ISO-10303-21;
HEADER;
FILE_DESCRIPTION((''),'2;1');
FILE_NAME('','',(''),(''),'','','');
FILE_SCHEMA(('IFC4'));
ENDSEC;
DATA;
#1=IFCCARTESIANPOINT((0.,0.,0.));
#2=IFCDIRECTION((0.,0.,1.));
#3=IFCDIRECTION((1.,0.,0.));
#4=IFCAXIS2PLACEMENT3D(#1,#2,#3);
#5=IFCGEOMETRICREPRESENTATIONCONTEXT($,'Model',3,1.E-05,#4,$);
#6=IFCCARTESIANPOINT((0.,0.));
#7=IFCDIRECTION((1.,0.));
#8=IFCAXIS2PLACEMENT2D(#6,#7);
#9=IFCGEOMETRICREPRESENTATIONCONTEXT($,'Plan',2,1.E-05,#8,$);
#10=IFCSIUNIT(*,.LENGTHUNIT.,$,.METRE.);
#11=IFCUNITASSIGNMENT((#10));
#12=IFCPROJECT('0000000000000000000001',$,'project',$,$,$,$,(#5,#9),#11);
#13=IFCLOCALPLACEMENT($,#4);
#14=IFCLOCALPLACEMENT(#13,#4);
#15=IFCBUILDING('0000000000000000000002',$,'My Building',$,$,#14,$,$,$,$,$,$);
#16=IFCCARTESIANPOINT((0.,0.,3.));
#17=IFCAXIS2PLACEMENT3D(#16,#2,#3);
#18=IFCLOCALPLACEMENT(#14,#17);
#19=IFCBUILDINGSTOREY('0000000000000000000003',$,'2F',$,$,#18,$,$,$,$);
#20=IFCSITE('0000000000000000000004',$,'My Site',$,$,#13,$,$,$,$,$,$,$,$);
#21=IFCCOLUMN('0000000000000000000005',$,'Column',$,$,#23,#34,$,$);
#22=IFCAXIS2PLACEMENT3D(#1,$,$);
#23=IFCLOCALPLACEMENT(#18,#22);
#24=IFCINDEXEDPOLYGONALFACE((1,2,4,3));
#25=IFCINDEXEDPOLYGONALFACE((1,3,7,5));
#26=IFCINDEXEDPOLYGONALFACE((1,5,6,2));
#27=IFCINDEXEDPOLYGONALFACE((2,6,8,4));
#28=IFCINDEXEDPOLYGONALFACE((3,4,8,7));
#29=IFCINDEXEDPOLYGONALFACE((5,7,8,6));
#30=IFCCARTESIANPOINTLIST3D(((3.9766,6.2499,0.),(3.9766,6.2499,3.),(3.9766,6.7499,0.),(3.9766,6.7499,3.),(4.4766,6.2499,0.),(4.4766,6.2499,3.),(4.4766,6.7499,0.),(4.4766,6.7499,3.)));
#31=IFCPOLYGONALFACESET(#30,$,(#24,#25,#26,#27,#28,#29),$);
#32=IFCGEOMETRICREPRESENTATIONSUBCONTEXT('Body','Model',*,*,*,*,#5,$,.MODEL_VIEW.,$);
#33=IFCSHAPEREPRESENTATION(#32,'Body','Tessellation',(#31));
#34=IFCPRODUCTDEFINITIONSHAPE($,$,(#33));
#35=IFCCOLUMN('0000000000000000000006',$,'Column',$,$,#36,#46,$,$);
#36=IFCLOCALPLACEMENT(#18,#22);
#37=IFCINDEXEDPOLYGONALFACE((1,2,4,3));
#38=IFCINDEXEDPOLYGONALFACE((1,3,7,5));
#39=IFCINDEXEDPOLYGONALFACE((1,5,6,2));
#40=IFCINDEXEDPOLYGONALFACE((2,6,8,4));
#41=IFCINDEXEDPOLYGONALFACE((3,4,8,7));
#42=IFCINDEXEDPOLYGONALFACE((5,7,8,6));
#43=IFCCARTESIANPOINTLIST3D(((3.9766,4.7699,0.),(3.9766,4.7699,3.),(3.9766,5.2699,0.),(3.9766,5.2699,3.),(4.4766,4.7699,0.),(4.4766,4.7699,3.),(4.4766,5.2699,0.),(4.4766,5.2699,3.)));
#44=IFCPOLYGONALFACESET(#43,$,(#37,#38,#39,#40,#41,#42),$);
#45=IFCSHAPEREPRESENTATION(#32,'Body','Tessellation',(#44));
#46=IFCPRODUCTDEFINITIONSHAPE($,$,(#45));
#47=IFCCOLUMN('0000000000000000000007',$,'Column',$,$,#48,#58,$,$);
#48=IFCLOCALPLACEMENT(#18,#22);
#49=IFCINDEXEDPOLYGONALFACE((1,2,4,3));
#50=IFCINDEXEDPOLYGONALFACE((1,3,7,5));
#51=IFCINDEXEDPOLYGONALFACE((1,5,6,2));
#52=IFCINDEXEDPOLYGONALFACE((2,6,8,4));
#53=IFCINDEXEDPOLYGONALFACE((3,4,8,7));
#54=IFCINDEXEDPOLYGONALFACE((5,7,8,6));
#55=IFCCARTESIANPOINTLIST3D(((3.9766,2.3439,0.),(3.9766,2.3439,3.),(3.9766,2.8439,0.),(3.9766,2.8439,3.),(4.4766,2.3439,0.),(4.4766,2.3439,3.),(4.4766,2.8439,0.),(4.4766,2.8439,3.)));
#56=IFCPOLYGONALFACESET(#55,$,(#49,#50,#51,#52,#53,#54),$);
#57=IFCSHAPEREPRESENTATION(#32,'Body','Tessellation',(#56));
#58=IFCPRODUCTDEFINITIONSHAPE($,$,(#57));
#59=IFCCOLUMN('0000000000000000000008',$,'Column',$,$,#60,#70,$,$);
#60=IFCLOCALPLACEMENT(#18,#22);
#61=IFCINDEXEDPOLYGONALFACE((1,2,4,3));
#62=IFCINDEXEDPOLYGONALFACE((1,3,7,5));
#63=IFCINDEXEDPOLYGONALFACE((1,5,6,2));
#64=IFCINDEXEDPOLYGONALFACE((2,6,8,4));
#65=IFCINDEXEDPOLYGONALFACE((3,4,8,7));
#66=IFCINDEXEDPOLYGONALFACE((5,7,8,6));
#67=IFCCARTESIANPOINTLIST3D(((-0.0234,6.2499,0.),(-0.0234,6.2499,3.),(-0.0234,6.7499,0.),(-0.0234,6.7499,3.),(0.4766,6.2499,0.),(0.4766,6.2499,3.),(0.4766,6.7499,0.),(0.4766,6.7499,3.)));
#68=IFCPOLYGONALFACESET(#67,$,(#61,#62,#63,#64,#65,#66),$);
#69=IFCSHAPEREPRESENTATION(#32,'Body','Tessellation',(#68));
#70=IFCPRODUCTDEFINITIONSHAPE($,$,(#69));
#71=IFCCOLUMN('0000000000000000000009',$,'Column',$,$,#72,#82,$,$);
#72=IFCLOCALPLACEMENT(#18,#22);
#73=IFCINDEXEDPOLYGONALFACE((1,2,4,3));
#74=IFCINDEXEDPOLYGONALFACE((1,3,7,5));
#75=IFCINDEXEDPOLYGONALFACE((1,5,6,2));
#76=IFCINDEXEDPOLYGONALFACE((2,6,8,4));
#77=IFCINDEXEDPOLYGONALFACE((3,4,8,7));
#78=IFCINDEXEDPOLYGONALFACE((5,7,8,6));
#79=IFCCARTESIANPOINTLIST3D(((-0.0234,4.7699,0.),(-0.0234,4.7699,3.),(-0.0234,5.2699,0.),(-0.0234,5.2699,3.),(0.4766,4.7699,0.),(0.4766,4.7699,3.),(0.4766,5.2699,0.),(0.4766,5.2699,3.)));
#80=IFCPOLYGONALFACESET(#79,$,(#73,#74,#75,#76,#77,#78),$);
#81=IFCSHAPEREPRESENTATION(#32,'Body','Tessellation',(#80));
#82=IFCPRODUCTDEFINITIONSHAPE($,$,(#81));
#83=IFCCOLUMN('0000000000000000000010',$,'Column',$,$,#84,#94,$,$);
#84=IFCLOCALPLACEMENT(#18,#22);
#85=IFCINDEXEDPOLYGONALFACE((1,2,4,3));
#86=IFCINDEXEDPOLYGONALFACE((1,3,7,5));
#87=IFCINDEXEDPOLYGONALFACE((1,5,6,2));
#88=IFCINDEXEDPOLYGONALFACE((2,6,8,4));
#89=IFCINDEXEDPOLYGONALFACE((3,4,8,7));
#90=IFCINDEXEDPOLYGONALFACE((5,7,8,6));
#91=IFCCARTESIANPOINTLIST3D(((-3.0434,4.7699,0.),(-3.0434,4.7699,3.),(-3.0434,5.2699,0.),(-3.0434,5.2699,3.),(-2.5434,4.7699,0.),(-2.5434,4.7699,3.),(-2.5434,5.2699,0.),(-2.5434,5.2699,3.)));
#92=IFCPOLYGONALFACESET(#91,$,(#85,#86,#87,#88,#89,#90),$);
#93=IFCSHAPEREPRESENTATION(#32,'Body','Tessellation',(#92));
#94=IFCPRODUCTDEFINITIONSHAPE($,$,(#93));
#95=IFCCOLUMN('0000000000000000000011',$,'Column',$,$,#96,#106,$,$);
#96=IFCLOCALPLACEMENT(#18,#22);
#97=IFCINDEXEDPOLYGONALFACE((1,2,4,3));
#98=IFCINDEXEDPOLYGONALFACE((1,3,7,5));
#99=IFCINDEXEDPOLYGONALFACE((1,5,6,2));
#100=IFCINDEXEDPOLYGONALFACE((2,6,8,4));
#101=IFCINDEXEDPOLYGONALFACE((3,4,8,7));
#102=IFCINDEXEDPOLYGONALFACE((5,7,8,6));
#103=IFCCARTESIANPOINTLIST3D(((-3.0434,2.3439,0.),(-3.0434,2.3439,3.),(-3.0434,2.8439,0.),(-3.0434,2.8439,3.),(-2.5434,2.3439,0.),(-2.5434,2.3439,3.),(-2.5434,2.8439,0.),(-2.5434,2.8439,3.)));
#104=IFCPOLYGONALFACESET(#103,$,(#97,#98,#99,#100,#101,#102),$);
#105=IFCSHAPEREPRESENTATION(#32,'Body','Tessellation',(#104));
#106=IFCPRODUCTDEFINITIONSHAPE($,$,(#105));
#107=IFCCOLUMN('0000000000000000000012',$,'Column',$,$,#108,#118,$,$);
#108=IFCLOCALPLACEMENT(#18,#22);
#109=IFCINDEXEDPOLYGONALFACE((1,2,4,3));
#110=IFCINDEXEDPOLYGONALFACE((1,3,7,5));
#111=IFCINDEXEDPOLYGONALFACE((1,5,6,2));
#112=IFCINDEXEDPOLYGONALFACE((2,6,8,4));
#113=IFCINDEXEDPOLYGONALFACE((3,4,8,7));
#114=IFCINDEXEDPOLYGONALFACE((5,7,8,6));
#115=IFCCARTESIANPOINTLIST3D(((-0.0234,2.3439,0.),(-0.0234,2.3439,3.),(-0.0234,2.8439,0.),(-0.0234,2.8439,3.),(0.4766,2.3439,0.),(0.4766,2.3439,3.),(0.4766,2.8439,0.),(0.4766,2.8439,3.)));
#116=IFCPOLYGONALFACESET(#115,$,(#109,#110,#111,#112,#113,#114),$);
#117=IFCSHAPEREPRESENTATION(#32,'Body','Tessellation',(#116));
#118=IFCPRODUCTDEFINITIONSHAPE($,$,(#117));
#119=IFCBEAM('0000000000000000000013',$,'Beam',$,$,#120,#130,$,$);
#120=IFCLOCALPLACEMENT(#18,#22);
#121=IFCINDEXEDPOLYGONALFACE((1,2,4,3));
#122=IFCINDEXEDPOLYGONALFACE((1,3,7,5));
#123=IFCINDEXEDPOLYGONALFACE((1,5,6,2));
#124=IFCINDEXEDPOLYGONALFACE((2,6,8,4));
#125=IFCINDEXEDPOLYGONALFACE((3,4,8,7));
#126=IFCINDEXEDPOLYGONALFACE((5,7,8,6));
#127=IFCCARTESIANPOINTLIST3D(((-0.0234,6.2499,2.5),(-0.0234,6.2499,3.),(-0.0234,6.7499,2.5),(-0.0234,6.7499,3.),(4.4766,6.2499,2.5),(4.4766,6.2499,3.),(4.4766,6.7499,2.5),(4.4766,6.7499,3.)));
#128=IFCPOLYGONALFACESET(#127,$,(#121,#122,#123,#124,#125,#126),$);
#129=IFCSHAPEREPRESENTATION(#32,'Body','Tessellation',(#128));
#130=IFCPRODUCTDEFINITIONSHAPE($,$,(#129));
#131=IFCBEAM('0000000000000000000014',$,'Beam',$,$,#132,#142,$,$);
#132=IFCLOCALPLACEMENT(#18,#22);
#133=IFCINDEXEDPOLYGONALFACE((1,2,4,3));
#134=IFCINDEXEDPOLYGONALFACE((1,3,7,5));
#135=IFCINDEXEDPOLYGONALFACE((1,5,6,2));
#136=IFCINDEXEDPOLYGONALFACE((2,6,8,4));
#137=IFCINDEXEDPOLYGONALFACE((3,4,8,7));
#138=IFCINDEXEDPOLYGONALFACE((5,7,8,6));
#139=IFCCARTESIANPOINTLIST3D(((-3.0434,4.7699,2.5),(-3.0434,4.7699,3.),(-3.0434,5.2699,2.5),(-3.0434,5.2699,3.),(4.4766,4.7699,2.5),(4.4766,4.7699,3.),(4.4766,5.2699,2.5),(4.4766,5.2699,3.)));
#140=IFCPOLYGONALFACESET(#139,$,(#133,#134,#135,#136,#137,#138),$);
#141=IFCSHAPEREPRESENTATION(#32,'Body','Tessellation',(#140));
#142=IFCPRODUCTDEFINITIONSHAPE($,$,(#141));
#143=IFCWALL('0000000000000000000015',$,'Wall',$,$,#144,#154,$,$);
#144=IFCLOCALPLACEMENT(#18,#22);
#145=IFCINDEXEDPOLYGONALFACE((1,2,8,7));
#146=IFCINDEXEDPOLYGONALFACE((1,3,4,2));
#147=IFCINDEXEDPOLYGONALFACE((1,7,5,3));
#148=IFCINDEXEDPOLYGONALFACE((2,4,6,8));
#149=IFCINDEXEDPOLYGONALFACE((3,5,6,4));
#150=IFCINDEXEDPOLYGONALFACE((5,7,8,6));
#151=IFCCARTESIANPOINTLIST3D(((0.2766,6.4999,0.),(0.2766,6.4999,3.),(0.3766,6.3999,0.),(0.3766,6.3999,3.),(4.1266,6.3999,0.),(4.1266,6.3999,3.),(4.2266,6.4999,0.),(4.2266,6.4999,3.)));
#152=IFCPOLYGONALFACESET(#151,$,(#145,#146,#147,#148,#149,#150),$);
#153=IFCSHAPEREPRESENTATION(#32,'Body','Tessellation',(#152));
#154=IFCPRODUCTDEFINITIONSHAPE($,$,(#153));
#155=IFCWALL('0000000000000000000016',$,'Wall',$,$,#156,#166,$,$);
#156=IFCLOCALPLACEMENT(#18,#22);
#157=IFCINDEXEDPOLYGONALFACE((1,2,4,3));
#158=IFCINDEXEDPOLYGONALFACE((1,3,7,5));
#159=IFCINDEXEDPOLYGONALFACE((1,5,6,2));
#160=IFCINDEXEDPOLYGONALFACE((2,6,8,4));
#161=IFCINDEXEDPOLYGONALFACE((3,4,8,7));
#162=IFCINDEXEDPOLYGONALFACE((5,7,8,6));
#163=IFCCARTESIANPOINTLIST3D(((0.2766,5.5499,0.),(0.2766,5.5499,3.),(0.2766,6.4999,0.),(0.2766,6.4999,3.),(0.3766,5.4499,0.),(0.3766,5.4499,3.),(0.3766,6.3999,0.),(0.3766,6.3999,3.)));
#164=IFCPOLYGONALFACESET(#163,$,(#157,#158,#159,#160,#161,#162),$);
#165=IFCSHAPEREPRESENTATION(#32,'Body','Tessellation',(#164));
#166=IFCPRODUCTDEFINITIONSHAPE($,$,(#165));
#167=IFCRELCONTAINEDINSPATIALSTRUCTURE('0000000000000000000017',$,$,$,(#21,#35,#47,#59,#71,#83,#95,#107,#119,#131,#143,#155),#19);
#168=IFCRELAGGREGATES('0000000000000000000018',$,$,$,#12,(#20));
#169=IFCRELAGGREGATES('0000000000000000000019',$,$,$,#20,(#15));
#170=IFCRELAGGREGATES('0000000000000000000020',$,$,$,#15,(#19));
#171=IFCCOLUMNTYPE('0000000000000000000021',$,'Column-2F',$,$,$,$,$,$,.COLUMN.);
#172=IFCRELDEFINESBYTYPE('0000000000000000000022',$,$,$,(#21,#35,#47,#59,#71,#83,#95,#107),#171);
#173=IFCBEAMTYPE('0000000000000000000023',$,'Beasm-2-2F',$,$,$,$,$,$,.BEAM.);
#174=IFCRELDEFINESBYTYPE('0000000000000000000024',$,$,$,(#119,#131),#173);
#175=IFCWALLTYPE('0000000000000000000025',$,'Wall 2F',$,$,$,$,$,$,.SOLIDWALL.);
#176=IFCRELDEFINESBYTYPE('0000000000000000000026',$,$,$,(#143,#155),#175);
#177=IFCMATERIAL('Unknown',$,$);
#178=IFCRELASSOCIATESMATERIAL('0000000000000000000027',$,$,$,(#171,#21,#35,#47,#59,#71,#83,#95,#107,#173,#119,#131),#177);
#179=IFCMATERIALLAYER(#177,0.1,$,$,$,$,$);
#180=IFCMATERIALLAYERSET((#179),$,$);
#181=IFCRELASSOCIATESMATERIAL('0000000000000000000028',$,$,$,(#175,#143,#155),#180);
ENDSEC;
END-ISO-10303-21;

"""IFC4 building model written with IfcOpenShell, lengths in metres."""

from ifc_helpers import new_model, si_unit, frame, origin_with_axes, origin_2d_with_axis, place, context, subcontext, project, spatial, line, indexed_curve, rectangle, outline, extrude, material, layer, layer_set, layer_usage, material_profile, profile_set, profile_usage, type_object, element, save


model = new_model("IFC4")

# Units and contexts
model_context = context("Model", 3, precision=1e-05, world=origin_with_axes())
plan_context = context("Plan", 2, precision=1e-05, world=origin_2d_with_axis())
body_context_1 = subcontext(model_context, "Body", "Model", "MODEL_VIEW")
ifc_project = project(units=[si_unit("LENGTHUNIT", "METRE")], contexts=[model_context, plan_context])

# Site, building, storey
site_placement = place(None, origin_with_axes())
site = spatial("IfcSite", under=ifc_project, at=site_placement, Name="My Site")
building_placement = place(site_placement, origin_with_axes())
building = spatial("IfcBuilding", under=site, at=building_placement, Name="My Building")
storey_placement = place(building_placement, frame((0.0, 0.0, 3.0), z_axis=(0.0, 0.0, 1.0), x_axis=(1.0, 0.0, 0.0)))
storey = spatial("IfcBuildingStorey", under=building, at=storey_placement, Name="2F")

# Columns
ifc_material = material(Name="Unknown")
ifc_material_profile_1 = material_profile(ifc_material, rectangle(XDim=0.5, YDim=0.5))
ifc_profile_set_1 = profile_set([ifc_material_profile_1])
ifc_profile_usage_1 = profile_usage(ifc_profile_set_1, cardinal=7)
column_type = type_object("IfcColumnType", Name="Column-2F", PredefinedType="COLUMN", material=ifc_profile_set_1)
column_1_placement = place(storey_placement, frame((4.4766, 6.7499, 0.0), z_axis=(0.0, 0.0, 1.0), x_axis=(1.0, 0.0, 0.0)))
element("IfcColumn", 1, at=column_1_placement, inside=storey, type_object=column_type, material=ifc_profile_usage_1, Name="Column", context=body_context_1, shape_type="SweptSolid", body=[
    extrude(rectangle(XDim=0.5, YDim=0.5), frame((-0.25, -0.25, 0.0), z_axis=(0.0, 0.0, 1.0), x_axis=(1.0, 0.0, 0.0)), (0.0, 0.0, 1.0), 3.0),
])
ifc_profile_usage_2 = profile_usage(ifc_profile_set_1, cardinal=7)
column_2_placement = place(storey_placement, frame((4.4766, 5.2699, 0.0), z_axis=(0.0, 0.0, 1.0), x_axis=(1.0, 0.0, 0.0)))
element("IfcColumn", 2, at=column_2_placement, inside=storey, type_object=column_type, material=ifc_profile_usage_2, Name="Column", context=body_context_1, shape_type="SweptSolid", body=[
    extrude(rectangle(XDim=0.5, YDim=0.5), frame((-0.25, -0.25, 0.0), z_axis=(0.0, 0.0, 1.0), x_axis=(1.0, 0.0, 0.0)), (0.0, 0.0, 1.0), 3.0),
])
ifc_profile_usage_3 = profile_usage(ifc_profile_set_1, cardinal=7)
column_3_placement = place(storey_placement, frame((4.4766, 2.8439, 0.0), z_axis=(0.0, 0.0, 1.0), x_axis=(1.0, 0.0, 0.0)))
element("IfcColumn", 3, at=column_3_placement, inside=storey, type_object=column_type, material=ifc_profile_usage_3, Name="Column", context=body_context_1, shape_type="SweptSolid", body=[
    extrude(rectangle(XDim=0.5, YDim=0.5), frame((-0.25, -0.25, 0.0), z_axis=(0.0, 0.0, 1.0), x_axis=(1.0, 0.0, 0.0)), (0.0, 0.0, 1.0), 3.0),
])
ifc_profile_usage_4 = profile_usage(ifc_profile_set_1, cardinal=7)
column_4_placement = place(storey_placement, frame((0.4766, 6.7499, 0.0), z_axis=(0.0, 0.0, 1.0), x_axis=(1.0, 0.0, 0.0)))
element("IfcColumn", 4, at=column_4_placement, inside=storey, type_object=column_type, material=ifc_profile_usage_4, Name="Column", context=body_context_1, shape_type="SweptSolid", body=[
    extrude(rectangle(XDim=0.5, YDim=0.5), frame((-0.25, -0.25, 0.0), z_axis=(0.0, 0.0, 1.0), x_axis=(1.0, 0.0, 0.0)), (0.0, 0.0, 1.0), 3.0),
])
ifc_profile_usage_5 = profile_usage(ifc_profile_set_1, cardinal=7)
column_5_placement = place(storey_placement, frame((0.4766, 5.2699, 0.0), z_axis=(0.0, 0.0, 1.0), x_axis=(1.0, 0.0, 0.0)))
element("IfcColumn", 5, at=column_5_placement, inside=storey, type_object=column_type, material=ifc_profile_usage_5, Name="Column", context=body_context_1, shape_type="SweptSolid", body=[
    extrude(rectangle(XDim=0.5, YDim=0.5), frame((-0.25, -0.25, 0.0), z_axis=(0.0, 0.0, 1.0), x_axis=(1.0, 0.0, 0.0)), (0.0, 0.0, 1.0), 3.0),
])
ifc_profile_usage_6 = profile_usage(ifc_profile_set_1, cardinal=7)
column_6_placement = place(storey_placement, frame((-2.5434, 5.2699, 0.0), z_axis=(0.0, 0.0, 1.0), x_axis=(1.0, 0.0, 0.0)))
element("IfcColumn", 6, at=column_6_placement, inside=storey, type_object=column_type, material=ifc_profile_usage_6, Name="Column", context=body_context_1, shape_type="SweptSolid", body=[
    extrude(rectangle(XDim=0.5, YDim=0.5), frame((-0.25, -0.25, 0.0), z_axis=(0.0, 0.0, 1.0), x_axis=(1.0, 0.0, 0.0)), (0.0, 0.0, 1.0), 3.0),
])
ifc_profile_usage_7 = profile_usage(ifc_profile_set_1, cardinal=7)
column_7_placement = place(storey_placement, frame((-2.5434, 2.8439, 0.0), z_axis=(0.0, 0.0, 1.0), x_axis=(1.0, 0.0, 0.0)))
element("IfcColumn", 7, at=column_7_placement, inside=storey, type_object=column_type, material=ifc_profile_usage_7, Name="Column", context=body_context_1, shape_type="SweptSolid", body=[
    extrude(rectangle(XDim=0.5, YDim=0.5), frame((-0.25, -0.25, 0.0), z_axis=(0.0, 0.0, 1.0), x_axis=(1.0, 0.0, 0.0)), (0.0, 0.0, 1.0), 3.0),
])
ifc_profile_usage_8 = profile_usage(ifc_profile_set_1, cardinal=7)
column_8_placement = place(storey_placement, frame((0.4766, 2.8439, 0.0), z_axis=(0.0, 0.0, 1.0), x_axis=(1.0, 0.0, 0.0)))
element("IfcColumn", 8, at=column_8_placement, inside=storey, type_object=column_type, material=ifc_profile_usage_8, Name="Column", context=body_context_1, shape_type="SweptSolid", body=[
    extrude(rectangle(XDim=0.5, YDim=0.5), frame((-0.25, -0.25, 0.0), z_axis=(0.0, 0.0, 1.0), x_axis=(1.0, 0.0, 0.0)), (0.0, 0.0, 1.0), 3.0),
])

# Beams
ifc_material_profile_2 = material_profile(ifc_material, rectangle(XDim=0.5, YDim=0.5))
ifc_profile_set_2 = profile_set([ifc_material_profile_2])
ifc_profile_usage_9 = profile_usage(ifc_profile_set_2, cardinal=7)
beam_type = type_object("IfcBeamType", Name="Beasm-2-2F", PredefinedType="BEAM", material=ifc_profile_set_2)
beam_1_placement = place(storey_placement, frame((4.4766, 6.2499, 3.0), z_axis=(-1.0, 0.0, 0.0), x_axis=(0.0, -1.0, 0.0)))
element("IfcBeam", 9, at=beam_1_placement, inside=storey, type_object=beam_type, material=ifc_profile_usage_9, Name="Beam", context=body_context_1, shape_type="SweptSolid", body=[
    extrude(rectangle(XDim=0.5, YDim=0.5), frame((-0.25, -0.25, 0.0), z_axis=(0.0, 0.0, 1.0), x_axis=(1.0, 0.0, 0.0)), (0.0, 0.0, 1.0), 4.5),
])
ifc_profile_usage_10 = profile_usage(ifc_profile_set_2, cardinal=7)
beam_2_placement = place(storey_placement, frame((4.4766, 4.7699, 3.0), z_axis=(-1.0, 0.0, 0.0), x_axis=(0.0, -1.0, 0.0)))
element("IfcBeam", 10, at=beam_2_placement, inside=storey, type_object=beam_type, material=ifc_profile_usage_10, Name="Beam", context=body_context_1, shape_type="SweptSolid", body=[
    extrude(rectangle(XDim=0.5, YDim=0.5), frame((-0.25, -0.25, 0.0), z_axis=(0.0, 0.0, 1.0), x_axis=(1.0, 0.0, 0.0)), (0.0, 0.0, 1.0), 7.52),
])

# Walls
ifc_layer = layer(ifc_material, 0.1)
ifc_layer_set = layer_set([ifc_layer])
ifc_layer_usage_1 = layer_usage(ifc_layer_set, "AXIS2", "POSITIVE", 0.0)
wall_type = type_object("IfcWallType", Name="Wall 2F", PredefinedType="SOLIDWALL", material=ifc_layer_set)
wall_1_placement = place(storey_placement, frame((4.2266, 6.4999, 0.0), z_axis=(0.0, 0.0, 1.0), x_axis=(-1.0, 0.0, 0.0)))
element("IfcWall", 11, at=wall_1_placement, inside=storey, type_object=wall_type, material=ifc_layer_usage_1, Name="Wall", context=body_context_1, shape_type="SweptSolid", body=[
    extrude(outline(indexed_curve([(0.0, 0.0), (0.1, 0.1), (3.85, 0.1), (3.95, 0.0)], segments=[line(1, 2, 3, 4, 1)])), origin_with_axes(), (0.0, 0.0, 1.0), 3.0),
])
ifc_layer_usage_2 = layer_usage(ifc_layer_set, "AXIS2", "POSITIVE", 0.0)
wall_2_placement = place(storey_placement, frame((0.2766, 6.4999, 0.0), z_axis=(0.0, 0.0, 1.0), x_axis=(0.0, -1.0, 0.0)))
element("IfcWall", 12, at=wall_2_placement, inside=storey, type_object=wall_type, material=ifc_layer_usage_2, Name="Wall", context=body_context_1, shape_type="SweptSolid", body=[
    extrude(outline(indexed_curve([(0.0, 0.0), (0.1, 0.1), (1.05, 0.1), (0.95, 0.0)], segments=[line(1, 2, 3, 4, 1)])), origin_with_axes(), (0.0, 0.0, 1.0), 3.0),
])

save(model, "model.ifc")
